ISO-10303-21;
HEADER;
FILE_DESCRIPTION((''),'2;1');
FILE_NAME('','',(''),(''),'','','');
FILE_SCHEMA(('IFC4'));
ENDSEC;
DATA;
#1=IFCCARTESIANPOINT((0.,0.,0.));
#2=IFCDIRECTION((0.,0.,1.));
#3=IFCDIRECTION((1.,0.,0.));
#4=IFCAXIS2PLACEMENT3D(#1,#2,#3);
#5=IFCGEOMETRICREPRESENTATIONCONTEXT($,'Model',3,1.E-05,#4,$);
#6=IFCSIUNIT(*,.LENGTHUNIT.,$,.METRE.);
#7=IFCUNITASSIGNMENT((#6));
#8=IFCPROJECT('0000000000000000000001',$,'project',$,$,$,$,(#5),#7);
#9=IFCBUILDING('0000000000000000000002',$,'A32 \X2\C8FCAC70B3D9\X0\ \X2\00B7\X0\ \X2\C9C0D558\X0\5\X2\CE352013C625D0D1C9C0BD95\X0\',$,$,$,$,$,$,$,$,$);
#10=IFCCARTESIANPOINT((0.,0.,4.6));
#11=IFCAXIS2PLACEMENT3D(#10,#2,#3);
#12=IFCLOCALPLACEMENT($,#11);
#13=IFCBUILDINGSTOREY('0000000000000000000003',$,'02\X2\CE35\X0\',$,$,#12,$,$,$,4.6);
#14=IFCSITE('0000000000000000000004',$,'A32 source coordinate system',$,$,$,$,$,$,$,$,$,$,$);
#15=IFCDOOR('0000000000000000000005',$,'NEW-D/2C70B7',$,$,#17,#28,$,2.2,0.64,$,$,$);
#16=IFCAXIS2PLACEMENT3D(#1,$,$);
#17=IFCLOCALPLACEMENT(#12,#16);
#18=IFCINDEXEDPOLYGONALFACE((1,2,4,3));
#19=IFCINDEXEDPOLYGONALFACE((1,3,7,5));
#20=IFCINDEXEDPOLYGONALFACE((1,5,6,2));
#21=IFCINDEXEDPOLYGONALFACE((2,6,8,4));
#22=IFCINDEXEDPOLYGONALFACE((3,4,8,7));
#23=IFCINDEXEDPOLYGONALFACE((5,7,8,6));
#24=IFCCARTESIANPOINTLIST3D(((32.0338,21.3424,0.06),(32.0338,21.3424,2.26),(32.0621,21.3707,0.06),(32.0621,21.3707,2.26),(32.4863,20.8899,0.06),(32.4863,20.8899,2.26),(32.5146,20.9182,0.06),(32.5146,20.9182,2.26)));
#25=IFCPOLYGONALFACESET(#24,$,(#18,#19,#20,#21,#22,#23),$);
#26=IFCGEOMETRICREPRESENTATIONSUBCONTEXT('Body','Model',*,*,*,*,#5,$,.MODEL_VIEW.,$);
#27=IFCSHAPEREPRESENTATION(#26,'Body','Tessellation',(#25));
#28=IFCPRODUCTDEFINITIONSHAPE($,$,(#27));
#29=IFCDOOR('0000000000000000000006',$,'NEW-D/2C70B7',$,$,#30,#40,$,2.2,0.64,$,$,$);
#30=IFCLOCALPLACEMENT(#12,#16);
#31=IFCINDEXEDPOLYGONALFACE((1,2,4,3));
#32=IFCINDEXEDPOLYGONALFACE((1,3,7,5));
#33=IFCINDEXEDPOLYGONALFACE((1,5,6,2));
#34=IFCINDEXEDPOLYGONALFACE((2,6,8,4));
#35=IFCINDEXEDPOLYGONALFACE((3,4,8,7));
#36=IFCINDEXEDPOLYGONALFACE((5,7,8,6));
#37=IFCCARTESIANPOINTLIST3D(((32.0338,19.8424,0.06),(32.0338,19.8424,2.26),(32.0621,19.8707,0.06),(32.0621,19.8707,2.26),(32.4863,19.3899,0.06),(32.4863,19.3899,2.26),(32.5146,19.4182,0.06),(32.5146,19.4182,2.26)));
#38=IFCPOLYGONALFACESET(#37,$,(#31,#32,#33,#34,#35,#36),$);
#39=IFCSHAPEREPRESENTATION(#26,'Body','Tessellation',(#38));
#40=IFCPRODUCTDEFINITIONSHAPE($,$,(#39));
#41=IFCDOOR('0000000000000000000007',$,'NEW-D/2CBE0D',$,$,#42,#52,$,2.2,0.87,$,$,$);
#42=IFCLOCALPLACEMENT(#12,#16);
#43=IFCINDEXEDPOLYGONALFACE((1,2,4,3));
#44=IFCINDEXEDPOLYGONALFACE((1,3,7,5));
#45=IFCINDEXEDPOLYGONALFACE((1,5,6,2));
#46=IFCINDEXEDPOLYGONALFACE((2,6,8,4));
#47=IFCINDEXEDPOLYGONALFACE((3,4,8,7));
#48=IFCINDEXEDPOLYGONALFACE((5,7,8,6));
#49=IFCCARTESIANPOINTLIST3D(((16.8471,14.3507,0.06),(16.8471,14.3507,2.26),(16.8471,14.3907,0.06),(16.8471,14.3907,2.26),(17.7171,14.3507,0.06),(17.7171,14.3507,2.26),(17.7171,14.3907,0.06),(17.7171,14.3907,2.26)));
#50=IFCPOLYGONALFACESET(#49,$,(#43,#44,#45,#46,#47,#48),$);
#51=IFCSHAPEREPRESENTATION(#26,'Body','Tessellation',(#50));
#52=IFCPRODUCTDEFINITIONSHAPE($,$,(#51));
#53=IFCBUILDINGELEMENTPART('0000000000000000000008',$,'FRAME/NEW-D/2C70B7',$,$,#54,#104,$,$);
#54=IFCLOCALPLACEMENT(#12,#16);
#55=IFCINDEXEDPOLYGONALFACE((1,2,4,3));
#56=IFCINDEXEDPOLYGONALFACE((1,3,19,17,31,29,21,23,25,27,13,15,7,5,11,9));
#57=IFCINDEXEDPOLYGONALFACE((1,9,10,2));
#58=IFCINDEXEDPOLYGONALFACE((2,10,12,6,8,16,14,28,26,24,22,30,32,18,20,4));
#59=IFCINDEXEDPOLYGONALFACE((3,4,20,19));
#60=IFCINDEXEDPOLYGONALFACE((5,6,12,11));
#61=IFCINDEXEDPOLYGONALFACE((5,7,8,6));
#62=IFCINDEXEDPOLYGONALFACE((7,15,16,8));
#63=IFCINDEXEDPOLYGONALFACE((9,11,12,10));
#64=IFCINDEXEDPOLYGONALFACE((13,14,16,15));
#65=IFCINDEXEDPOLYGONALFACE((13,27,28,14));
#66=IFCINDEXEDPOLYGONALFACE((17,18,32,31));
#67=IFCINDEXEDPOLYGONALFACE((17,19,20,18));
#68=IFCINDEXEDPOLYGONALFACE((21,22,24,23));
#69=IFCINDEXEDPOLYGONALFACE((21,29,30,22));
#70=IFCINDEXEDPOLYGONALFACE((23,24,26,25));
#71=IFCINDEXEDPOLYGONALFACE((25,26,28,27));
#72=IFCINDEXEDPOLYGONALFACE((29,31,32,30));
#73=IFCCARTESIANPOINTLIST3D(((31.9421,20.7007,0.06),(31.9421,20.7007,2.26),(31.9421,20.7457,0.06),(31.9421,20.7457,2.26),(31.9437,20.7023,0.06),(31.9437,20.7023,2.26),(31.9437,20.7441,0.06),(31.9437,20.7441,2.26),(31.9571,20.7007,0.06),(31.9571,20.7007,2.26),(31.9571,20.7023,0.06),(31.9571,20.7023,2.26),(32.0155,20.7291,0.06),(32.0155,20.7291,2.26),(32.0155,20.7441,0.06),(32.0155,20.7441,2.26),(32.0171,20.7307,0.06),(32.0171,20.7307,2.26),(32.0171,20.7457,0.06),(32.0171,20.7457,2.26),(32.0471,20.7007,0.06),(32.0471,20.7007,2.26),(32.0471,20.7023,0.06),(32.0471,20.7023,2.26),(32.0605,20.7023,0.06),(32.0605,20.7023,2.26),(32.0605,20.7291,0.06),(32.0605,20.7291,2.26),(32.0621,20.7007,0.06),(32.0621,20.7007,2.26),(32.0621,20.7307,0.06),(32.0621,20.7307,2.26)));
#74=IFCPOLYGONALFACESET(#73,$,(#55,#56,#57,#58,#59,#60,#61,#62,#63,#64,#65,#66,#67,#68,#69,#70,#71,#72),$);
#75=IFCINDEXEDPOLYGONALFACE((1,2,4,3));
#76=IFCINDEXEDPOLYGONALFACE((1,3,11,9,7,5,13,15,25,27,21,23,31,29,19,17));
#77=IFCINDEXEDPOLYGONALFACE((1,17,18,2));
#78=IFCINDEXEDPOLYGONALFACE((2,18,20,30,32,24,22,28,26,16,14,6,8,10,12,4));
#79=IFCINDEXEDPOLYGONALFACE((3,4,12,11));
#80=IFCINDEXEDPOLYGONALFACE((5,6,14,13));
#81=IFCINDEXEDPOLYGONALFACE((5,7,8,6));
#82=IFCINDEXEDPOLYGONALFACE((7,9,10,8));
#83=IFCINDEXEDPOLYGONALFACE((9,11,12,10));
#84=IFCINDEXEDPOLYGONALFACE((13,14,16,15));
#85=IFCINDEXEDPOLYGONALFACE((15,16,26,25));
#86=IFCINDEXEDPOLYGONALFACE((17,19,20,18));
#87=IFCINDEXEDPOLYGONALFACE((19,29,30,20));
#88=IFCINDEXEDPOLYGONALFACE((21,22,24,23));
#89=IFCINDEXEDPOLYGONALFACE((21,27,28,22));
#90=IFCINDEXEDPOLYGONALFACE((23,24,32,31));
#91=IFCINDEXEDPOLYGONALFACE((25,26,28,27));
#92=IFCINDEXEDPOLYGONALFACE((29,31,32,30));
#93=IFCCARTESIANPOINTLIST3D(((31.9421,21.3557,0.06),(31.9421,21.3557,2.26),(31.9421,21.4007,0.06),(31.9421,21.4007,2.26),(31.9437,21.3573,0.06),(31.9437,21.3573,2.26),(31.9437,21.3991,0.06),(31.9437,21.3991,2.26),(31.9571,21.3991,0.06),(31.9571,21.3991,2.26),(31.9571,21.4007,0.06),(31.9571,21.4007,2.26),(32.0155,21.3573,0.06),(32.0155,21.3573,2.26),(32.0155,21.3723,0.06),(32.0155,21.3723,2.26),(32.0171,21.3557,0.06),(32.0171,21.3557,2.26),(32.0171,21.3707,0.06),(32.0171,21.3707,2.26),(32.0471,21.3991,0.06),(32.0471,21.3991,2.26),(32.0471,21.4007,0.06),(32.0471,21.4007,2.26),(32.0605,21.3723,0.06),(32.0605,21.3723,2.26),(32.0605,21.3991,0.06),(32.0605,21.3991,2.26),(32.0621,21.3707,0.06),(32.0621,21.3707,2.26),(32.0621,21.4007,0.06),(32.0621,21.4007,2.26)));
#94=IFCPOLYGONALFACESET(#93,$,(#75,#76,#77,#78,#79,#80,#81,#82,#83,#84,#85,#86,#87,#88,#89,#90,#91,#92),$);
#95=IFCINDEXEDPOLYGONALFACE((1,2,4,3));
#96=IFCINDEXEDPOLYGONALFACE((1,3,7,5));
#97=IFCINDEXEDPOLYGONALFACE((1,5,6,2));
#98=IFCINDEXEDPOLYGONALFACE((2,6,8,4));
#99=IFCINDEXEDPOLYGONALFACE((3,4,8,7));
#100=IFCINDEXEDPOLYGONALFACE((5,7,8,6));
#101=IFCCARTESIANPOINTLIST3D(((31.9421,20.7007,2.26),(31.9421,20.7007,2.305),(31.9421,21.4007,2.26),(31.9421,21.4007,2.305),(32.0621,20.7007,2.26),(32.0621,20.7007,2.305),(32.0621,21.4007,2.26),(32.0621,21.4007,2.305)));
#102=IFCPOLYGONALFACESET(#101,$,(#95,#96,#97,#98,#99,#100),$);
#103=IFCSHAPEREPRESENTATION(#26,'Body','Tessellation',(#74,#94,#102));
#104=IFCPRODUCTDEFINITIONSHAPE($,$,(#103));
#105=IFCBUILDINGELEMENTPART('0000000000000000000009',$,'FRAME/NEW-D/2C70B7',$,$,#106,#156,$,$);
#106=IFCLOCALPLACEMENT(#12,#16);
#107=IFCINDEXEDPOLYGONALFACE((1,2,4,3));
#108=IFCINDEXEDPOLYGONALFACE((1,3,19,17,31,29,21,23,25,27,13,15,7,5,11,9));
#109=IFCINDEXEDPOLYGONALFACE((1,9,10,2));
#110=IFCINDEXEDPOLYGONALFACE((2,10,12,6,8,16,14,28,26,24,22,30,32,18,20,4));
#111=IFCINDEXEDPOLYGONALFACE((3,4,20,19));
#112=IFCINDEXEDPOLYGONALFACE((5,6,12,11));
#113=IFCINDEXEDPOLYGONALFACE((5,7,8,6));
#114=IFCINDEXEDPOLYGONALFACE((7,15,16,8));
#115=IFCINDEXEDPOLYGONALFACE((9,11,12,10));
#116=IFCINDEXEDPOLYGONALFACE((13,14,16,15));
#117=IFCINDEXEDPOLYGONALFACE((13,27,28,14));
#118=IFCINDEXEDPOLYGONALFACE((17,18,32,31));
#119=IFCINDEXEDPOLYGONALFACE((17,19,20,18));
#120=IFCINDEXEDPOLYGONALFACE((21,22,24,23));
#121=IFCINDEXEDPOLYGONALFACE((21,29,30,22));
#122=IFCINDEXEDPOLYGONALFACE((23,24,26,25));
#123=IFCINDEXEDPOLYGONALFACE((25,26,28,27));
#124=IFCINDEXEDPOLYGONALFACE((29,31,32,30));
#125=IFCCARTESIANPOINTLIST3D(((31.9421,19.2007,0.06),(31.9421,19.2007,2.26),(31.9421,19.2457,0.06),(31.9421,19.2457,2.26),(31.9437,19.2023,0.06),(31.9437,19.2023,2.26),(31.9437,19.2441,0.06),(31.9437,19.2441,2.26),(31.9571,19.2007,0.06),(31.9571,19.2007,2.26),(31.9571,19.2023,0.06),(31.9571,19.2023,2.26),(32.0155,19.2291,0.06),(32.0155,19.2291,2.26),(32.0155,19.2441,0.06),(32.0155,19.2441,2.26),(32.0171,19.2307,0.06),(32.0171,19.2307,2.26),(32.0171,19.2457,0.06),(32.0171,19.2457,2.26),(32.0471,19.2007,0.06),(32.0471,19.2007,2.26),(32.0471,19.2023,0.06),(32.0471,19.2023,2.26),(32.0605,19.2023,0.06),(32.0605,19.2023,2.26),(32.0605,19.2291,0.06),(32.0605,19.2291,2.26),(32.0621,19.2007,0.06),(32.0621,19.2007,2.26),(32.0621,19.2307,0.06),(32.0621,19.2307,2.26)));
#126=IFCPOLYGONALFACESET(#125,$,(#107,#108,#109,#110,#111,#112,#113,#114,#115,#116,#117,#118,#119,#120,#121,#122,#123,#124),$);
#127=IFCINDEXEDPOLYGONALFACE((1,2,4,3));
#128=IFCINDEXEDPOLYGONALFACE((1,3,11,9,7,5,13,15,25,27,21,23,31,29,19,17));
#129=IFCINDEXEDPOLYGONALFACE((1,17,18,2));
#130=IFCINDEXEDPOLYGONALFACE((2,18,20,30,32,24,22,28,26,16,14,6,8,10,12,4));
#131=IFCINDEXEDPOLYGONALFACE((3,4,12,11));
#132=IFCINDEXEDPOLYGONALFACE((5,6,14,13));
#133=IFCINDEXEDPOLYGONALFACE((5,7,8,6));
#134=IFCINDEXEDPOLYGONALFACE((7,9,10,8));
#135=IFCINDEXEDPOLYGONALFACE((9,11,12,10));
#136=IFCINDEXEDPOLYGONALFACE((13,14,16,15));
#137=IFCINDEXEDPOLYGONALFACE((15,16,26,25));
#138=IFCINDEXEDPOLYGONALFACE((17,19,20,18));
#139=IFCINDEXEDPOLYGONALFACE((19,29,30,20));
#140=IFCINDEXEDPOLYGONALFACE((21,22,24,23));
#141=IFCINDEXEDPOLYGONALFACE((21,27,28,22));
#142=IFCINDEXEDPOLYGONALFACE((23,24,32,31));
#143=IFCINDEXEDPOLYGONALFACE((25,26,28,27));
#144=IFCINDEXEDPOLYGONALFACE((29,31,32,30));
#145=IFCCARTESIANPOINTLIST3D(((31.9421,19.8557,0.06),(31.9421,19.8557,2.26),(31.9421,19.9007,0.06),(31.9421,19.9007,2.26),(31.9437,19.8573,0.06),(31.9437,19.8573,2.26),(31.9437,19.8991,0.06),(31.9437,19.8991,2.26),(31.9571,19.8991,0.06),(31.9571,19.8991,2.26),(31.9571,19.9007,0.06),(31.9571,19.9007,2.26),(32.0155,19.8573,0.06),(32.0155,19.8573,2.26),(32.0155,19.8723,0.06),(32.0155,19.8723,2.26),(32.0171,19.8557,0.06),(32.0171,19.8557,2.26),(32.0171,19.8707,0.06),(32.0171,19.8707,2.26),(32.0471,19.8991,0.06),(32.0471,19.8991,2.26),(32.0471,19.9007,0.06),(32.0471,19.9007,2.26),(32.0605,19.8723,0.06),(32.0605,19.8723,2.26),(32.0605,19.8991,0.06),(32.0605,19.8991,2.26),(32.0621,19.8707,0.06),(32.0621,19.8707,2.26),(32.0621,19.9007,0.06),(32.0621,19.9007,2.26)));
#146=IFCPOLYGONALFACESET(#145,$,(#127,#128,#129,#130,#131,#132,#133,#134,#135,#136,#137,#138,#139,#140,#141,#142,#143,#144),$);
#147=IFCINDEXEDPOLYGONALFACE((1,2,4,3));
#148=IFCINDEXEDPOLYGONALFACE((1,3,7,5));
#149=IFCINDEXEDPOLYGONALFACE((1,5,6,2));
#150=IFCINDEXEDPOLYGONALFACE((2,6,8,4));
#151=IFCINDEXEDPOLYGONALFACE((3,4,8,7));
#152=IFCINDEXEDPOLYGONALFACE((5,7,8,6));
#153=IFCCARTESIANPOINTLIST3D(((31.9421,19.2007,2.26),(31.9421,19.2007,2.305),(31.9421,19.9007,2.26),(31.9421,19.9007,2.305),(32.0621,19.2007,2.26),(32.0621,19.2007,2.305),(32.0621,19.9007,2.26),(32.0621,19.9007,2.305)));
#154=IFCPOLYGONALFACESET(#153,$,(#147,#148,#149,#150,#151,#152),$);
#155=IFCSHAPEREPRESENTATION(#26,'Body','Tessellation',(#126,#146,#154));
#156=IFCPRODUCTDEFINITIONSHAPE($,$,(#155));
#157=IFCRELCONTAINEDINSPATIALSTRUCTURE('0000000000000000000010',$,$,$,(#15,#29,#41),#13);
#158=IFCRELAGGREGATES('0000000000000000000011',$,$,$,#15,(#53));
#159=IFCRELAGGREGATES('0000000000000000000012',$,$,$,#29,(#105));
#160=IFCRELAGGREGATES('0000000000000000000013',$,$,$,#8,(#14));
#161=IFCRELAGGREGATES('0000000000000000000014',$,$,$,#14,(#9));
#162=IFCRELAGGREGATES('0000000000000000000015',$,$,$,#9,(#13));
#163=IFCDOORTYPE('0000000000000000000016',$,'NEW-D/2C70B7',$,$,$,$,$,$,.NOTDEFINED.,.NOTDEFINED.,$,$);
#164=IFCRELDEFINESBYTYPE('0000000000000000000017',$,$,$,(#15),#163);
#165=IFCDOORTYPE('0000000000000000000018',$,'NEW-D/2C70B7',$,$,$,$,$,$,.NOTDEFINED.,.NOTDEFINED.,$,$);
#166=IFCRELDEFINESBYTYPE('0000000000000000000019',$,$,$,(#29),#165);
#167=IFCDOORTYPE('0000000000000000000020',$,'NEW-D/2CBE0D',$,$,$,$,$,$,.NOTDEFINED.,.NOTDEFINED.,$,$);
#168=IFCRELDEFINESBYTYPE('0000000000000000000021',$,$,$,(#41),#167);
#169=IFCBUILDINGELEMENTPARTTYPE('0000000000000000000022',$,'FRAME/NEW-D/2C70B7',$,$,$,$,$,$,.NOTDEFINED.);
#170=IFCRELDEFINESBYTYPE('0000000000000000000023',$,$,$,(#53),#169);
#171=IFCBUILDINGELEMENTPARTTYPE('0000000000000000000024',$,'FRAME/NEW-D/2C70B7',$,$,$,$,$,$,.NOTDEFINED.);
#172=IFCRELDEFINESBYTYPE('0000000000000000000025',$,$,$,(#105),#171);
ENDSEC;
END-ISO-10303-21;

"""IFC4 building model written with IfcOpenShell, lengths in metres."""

from ifc_helpers import new_model, si_unit, frame, origin, origin_with_axes, place, context, subcontext, project, spatial, polyline, outline, extrude, source, transform, mapped, type_object, type_shapes, element, aggregate, save


model = new_model("IFC4")

# Units and contexts
model_context = context("Model", 3, precision=1e-05, world=origin_with_axes())
body_context = subcontext(model_context, "Body", "Model", "MODEL_VIEW")
ifc_project = project(units=[si_unit("LENGTHUNIT", "METRE")], contexts=[model_context])

# Site, building, storey
storey_placement = place(None, frame((0.0, 0.0, 4.6), z_axis=(0.0, 0.0, 1.0), x_axis=(1.0, 0.0, 0.0)))
site = spatial("IfcSite", under=ifc_project, Name="A32 source coordinate system")
building = spatial("IfcBuilding", under=site, Name="A32 주거동 · 지하5층–옥탑지붕")
storey = spatial("IfcBuildingStorey", under=building, at=storey_placement, Name="02층", Elevation=4.6)

# Doors
door_type_1 = type_object("IfcDoorType", Name="NEW-D/2C70B7", OperationType="NOTDEFINED", PredefinedType="NOTDEFINED")
shared_shape_1 = source(origin(), body_context, "Body", "SweptSolid", [
    extrude(outline(polyline([(32.4863, 20.8899), (32.0338, 21.3424), (32.0621, 21.3707), (32.5146, 20.9182), (32.4863, 20.8899)])), frame((0.0, 0.0, 0.06)), (0.0, 0.0, 1.0), 2.2),
])
type_shapes(door_type_1, [shared_shape_1])
door_1_placement = place(storey_placement, origin_with_axes())
door_1 = element("IfcDoor", 1, at=door_1_placement, inside=storey, type_object=door_type_1, Name="NEW-D/2C70B7", OverallHeight=2.2, OverallWidth=0.64, context=body_context, shape_type="MappedRepresentation", body=[
    mapped(shared_shape_1, transform((0.0, 0.0, 0.0), scale=1.0)),
])
door_type_2 = type_object("IfcDoorType", Name="NEW-D/2C70B7", OperationType="NOTDEFINED", PredefinedType="NOTDEFINED")
shared_shape_2 = source(origin(), body_context, "Body", "SweptSolid", [
    extrude(outline(polyline([(32.4863, 19.3899), (32.0338, 19.8424), (32.0621, 19.8707), (32.5146, 19.4182), (32.4863, 19.3899)])), frame((0.0, 0.0, 0.06)), (0.0, 0.0, 1.0), 2.2),
])
type_shapes(door_type_2, [shared_shape_2])
door_2_placement = place(storey_placement, origin_with_axes())
door_2 = element("IfcDoor", 2, at=door_2_placement, inside=storey, type_object=door_type_2, Name="NEW-D/2C70B7", OverallHeight=2.2, OverallWidth=0.64, context=body_context, shape_type="MappedRepresentation", body=[
    mapped(shared_shape_2, transform((0.0, 0.0, 0.0), scale=1.0)),
])
door_type_3 = type_object("IfcDoorType", Name="NEW-D/2CBE0D", OperationType="NOTDEFINED", PredefinedType="NOTDEFINED")
shared_shape_3 = source(origin(), body_context, "Body", "SweptSolid", [
    extrude(outline(polyline([(17.7171, 14.3907), (17.7171, 14.3507), (16.8471, 14.3507), (16.8471, 14.3907), (17.7171, 14.3907)])), frame((0.0, 0.0, 0.06)), (0.0, 0.0, 1.0), 2.2),
])
type_shapes(door_type_3, [shared_shape_3])
door_3_placement = place(storey_placement, origin_with_axes())
element("IfcDoor", 3, at=door_3_placement, inside=storey, type_object=door_type_3, Name="NEW-D/2CBE0D", OverallHeight=2.2, OverallWidth=0.87, context=body_context, shape_type="MappedRepresentation", body=[
    mapped(shared_shape_3, transform((0.0, 0.0, 0.0), scale=1.0)),
])

# Building element parts
building_element_part_type_1 = type_object("IfcBuildingElementPartType", Name="FRAME/NEW-D/2C70B7", PredefinedType="NOTDEFINED")
shared_shape_4 = source(origin(), body_context, "Body", "SweptSolid", [
    extrude(outline(polyline([(32.0605, 20.7291), (32.0155, 20.7291), (32.0155, 20.7441), (31.9437, 20.7441), (31.9437, 20.7023), (31.9571, 20.7023), (31.9571, 20.7007), (31.9421, 20.7007), (31.9421, 20.7457), (32.0171, 20.7457), (32.0171, 20.7307), (32.0621, 20.7307), (32.0621, 20.7007), (32.0471, 20.7007), (32.0471, 20.7023), (32.0605, 20.7023), (32.0605, 20.7291)])), frame((0.0, 0.0, 0.06)), (0.0, 0.0, 1.0), 2.2),
    extrude(outline(polyline([(32.0621, 21.4007), (32.0621, 21.3707), (32.0171, 21.3707), (32.0171, 21.3557), (31.9421, 21.3557), (31.9421, 21.4007), (31.9571, 21.4007), (31.9571, 21.3991), (31.9437, 21.3991), (31.9437, 21.3573), (32.0155, 21.3573), (32.0155, 21.3723), (32.0605, 21.3723), (32.0605, 21.3991), (32.0471, 21.3991), (32.0471, 21.4007), (32.0621, 21.4007)])), frame((0.0, 0.0, 0.06)), (0.0, 0.0, 1.0), 2.2),
    extrude(outline(polyline([(32.0621, 20.7007), (32.0621, 21.4007), (31.9421, 21.4007), (31.9421, 20.7007), (32.0621, 20.7007)])), frame((0.0, 0.0, 2.26)), (0.0, 0.0, 1.0), 0.045),
])
type_shapes(building_element_part_type_1, [shared_shape_4])
building_element_part_1_placement = place(door_1_placement, origin_with_axes())
building_element_part_1 = element("IfcBuildingElementPart", 4, at=building_element_part_1_placement, type_object=building_element_part_type_1, Name="FRAME/NEW-D/2C70B7", context=body_context, shape_type="MappedRepresentation", body=[
    mapped(shared_shape_4, transform((0.0, 0.0, 0.0), scale=1.0)),
])
aggregate(door_1, [building_element_part_1])
building_element_part_type_2 = type_object("IfcBuildingElementPartType", Name="FRAME/NEW-D/2C70B7", PredefinedType="NOTDEFINED")
shared_shape_5 = source(origin(), body_context, "Body", "SweptSolid", [
    extrude(outline(polyline([(32.0605, 19.2291), (32.0155, 19.2291), (32.0155, 19.2441), (31.9437, 19.2441), (31.9437, 19.2023), (31.9571, 19.2023), (31.9571, 19.2007), (31.9421, 19.2007), (31.9421, 19.2457), (32.0171, 19.2457), (32.0171, 19.2307), (32.0621, 19.2307), (32.0621, 19.2007), (32.0471, 19.2007), (32.0471, 19.2023), (32.0605, 19.2023), (32.0605, 19.2291)])), frame((0.0, 0.0, 0.06)), (0.0, 0.0, 1.0), 2.2),
    extrude(outline(polyline([(32.0621, 19.9007), (32.0621, 19.8707), (32.0171, 19.8707), (32.0171, 19.8557), (31.9421, 19.8557), (31.9421, 19.9007), (31.9571, 19.9007), (31.9571, 19.8991), (31.9437, 19.8991), (31.9437, 19.8573), (32.0155, 19.8573), (32.0155, 19.8723), (32.0605, 19.8723), (32.0605, 19.8991), (32.0471, 19.8991), (32.0471, 19.9007), (32.0621, 19.9007)])), frame((0.0, 0.0, 0.06)), (0.0, 0.0, 1.0), 2.2),
    extrude(outline(polyline([(32.0621, 19.2007), (32.0621, 19.9007), (31.9421, 19.9007), (31.9421, 19.2007), (32.0621, 19.2007)])), frame((0.0, 0.0, 2.26)), (0.0, 0.0, 1.0), 0.045),
])
type_shapes(building_element_part_type_2, [shared_shape_5])
building_element_part_2_placement = place(door_2_placement, origin_with_axes())
building_element_part_2 = element("IfcBuildingElementPart", 5, at=building_element_part_2_placement, type_object=building_element_part_type_2, Name="FRAME/NEW-D/2C70B7", context=body_context, shape_type="MappedRepresentation", body=[
    mapped(shared_shape_5, transform((0.0, 0.0, 0.0), scale=1.0)),
])
aggregate(door_2, [building_element_part_2])

save(model, "model.ifc")
